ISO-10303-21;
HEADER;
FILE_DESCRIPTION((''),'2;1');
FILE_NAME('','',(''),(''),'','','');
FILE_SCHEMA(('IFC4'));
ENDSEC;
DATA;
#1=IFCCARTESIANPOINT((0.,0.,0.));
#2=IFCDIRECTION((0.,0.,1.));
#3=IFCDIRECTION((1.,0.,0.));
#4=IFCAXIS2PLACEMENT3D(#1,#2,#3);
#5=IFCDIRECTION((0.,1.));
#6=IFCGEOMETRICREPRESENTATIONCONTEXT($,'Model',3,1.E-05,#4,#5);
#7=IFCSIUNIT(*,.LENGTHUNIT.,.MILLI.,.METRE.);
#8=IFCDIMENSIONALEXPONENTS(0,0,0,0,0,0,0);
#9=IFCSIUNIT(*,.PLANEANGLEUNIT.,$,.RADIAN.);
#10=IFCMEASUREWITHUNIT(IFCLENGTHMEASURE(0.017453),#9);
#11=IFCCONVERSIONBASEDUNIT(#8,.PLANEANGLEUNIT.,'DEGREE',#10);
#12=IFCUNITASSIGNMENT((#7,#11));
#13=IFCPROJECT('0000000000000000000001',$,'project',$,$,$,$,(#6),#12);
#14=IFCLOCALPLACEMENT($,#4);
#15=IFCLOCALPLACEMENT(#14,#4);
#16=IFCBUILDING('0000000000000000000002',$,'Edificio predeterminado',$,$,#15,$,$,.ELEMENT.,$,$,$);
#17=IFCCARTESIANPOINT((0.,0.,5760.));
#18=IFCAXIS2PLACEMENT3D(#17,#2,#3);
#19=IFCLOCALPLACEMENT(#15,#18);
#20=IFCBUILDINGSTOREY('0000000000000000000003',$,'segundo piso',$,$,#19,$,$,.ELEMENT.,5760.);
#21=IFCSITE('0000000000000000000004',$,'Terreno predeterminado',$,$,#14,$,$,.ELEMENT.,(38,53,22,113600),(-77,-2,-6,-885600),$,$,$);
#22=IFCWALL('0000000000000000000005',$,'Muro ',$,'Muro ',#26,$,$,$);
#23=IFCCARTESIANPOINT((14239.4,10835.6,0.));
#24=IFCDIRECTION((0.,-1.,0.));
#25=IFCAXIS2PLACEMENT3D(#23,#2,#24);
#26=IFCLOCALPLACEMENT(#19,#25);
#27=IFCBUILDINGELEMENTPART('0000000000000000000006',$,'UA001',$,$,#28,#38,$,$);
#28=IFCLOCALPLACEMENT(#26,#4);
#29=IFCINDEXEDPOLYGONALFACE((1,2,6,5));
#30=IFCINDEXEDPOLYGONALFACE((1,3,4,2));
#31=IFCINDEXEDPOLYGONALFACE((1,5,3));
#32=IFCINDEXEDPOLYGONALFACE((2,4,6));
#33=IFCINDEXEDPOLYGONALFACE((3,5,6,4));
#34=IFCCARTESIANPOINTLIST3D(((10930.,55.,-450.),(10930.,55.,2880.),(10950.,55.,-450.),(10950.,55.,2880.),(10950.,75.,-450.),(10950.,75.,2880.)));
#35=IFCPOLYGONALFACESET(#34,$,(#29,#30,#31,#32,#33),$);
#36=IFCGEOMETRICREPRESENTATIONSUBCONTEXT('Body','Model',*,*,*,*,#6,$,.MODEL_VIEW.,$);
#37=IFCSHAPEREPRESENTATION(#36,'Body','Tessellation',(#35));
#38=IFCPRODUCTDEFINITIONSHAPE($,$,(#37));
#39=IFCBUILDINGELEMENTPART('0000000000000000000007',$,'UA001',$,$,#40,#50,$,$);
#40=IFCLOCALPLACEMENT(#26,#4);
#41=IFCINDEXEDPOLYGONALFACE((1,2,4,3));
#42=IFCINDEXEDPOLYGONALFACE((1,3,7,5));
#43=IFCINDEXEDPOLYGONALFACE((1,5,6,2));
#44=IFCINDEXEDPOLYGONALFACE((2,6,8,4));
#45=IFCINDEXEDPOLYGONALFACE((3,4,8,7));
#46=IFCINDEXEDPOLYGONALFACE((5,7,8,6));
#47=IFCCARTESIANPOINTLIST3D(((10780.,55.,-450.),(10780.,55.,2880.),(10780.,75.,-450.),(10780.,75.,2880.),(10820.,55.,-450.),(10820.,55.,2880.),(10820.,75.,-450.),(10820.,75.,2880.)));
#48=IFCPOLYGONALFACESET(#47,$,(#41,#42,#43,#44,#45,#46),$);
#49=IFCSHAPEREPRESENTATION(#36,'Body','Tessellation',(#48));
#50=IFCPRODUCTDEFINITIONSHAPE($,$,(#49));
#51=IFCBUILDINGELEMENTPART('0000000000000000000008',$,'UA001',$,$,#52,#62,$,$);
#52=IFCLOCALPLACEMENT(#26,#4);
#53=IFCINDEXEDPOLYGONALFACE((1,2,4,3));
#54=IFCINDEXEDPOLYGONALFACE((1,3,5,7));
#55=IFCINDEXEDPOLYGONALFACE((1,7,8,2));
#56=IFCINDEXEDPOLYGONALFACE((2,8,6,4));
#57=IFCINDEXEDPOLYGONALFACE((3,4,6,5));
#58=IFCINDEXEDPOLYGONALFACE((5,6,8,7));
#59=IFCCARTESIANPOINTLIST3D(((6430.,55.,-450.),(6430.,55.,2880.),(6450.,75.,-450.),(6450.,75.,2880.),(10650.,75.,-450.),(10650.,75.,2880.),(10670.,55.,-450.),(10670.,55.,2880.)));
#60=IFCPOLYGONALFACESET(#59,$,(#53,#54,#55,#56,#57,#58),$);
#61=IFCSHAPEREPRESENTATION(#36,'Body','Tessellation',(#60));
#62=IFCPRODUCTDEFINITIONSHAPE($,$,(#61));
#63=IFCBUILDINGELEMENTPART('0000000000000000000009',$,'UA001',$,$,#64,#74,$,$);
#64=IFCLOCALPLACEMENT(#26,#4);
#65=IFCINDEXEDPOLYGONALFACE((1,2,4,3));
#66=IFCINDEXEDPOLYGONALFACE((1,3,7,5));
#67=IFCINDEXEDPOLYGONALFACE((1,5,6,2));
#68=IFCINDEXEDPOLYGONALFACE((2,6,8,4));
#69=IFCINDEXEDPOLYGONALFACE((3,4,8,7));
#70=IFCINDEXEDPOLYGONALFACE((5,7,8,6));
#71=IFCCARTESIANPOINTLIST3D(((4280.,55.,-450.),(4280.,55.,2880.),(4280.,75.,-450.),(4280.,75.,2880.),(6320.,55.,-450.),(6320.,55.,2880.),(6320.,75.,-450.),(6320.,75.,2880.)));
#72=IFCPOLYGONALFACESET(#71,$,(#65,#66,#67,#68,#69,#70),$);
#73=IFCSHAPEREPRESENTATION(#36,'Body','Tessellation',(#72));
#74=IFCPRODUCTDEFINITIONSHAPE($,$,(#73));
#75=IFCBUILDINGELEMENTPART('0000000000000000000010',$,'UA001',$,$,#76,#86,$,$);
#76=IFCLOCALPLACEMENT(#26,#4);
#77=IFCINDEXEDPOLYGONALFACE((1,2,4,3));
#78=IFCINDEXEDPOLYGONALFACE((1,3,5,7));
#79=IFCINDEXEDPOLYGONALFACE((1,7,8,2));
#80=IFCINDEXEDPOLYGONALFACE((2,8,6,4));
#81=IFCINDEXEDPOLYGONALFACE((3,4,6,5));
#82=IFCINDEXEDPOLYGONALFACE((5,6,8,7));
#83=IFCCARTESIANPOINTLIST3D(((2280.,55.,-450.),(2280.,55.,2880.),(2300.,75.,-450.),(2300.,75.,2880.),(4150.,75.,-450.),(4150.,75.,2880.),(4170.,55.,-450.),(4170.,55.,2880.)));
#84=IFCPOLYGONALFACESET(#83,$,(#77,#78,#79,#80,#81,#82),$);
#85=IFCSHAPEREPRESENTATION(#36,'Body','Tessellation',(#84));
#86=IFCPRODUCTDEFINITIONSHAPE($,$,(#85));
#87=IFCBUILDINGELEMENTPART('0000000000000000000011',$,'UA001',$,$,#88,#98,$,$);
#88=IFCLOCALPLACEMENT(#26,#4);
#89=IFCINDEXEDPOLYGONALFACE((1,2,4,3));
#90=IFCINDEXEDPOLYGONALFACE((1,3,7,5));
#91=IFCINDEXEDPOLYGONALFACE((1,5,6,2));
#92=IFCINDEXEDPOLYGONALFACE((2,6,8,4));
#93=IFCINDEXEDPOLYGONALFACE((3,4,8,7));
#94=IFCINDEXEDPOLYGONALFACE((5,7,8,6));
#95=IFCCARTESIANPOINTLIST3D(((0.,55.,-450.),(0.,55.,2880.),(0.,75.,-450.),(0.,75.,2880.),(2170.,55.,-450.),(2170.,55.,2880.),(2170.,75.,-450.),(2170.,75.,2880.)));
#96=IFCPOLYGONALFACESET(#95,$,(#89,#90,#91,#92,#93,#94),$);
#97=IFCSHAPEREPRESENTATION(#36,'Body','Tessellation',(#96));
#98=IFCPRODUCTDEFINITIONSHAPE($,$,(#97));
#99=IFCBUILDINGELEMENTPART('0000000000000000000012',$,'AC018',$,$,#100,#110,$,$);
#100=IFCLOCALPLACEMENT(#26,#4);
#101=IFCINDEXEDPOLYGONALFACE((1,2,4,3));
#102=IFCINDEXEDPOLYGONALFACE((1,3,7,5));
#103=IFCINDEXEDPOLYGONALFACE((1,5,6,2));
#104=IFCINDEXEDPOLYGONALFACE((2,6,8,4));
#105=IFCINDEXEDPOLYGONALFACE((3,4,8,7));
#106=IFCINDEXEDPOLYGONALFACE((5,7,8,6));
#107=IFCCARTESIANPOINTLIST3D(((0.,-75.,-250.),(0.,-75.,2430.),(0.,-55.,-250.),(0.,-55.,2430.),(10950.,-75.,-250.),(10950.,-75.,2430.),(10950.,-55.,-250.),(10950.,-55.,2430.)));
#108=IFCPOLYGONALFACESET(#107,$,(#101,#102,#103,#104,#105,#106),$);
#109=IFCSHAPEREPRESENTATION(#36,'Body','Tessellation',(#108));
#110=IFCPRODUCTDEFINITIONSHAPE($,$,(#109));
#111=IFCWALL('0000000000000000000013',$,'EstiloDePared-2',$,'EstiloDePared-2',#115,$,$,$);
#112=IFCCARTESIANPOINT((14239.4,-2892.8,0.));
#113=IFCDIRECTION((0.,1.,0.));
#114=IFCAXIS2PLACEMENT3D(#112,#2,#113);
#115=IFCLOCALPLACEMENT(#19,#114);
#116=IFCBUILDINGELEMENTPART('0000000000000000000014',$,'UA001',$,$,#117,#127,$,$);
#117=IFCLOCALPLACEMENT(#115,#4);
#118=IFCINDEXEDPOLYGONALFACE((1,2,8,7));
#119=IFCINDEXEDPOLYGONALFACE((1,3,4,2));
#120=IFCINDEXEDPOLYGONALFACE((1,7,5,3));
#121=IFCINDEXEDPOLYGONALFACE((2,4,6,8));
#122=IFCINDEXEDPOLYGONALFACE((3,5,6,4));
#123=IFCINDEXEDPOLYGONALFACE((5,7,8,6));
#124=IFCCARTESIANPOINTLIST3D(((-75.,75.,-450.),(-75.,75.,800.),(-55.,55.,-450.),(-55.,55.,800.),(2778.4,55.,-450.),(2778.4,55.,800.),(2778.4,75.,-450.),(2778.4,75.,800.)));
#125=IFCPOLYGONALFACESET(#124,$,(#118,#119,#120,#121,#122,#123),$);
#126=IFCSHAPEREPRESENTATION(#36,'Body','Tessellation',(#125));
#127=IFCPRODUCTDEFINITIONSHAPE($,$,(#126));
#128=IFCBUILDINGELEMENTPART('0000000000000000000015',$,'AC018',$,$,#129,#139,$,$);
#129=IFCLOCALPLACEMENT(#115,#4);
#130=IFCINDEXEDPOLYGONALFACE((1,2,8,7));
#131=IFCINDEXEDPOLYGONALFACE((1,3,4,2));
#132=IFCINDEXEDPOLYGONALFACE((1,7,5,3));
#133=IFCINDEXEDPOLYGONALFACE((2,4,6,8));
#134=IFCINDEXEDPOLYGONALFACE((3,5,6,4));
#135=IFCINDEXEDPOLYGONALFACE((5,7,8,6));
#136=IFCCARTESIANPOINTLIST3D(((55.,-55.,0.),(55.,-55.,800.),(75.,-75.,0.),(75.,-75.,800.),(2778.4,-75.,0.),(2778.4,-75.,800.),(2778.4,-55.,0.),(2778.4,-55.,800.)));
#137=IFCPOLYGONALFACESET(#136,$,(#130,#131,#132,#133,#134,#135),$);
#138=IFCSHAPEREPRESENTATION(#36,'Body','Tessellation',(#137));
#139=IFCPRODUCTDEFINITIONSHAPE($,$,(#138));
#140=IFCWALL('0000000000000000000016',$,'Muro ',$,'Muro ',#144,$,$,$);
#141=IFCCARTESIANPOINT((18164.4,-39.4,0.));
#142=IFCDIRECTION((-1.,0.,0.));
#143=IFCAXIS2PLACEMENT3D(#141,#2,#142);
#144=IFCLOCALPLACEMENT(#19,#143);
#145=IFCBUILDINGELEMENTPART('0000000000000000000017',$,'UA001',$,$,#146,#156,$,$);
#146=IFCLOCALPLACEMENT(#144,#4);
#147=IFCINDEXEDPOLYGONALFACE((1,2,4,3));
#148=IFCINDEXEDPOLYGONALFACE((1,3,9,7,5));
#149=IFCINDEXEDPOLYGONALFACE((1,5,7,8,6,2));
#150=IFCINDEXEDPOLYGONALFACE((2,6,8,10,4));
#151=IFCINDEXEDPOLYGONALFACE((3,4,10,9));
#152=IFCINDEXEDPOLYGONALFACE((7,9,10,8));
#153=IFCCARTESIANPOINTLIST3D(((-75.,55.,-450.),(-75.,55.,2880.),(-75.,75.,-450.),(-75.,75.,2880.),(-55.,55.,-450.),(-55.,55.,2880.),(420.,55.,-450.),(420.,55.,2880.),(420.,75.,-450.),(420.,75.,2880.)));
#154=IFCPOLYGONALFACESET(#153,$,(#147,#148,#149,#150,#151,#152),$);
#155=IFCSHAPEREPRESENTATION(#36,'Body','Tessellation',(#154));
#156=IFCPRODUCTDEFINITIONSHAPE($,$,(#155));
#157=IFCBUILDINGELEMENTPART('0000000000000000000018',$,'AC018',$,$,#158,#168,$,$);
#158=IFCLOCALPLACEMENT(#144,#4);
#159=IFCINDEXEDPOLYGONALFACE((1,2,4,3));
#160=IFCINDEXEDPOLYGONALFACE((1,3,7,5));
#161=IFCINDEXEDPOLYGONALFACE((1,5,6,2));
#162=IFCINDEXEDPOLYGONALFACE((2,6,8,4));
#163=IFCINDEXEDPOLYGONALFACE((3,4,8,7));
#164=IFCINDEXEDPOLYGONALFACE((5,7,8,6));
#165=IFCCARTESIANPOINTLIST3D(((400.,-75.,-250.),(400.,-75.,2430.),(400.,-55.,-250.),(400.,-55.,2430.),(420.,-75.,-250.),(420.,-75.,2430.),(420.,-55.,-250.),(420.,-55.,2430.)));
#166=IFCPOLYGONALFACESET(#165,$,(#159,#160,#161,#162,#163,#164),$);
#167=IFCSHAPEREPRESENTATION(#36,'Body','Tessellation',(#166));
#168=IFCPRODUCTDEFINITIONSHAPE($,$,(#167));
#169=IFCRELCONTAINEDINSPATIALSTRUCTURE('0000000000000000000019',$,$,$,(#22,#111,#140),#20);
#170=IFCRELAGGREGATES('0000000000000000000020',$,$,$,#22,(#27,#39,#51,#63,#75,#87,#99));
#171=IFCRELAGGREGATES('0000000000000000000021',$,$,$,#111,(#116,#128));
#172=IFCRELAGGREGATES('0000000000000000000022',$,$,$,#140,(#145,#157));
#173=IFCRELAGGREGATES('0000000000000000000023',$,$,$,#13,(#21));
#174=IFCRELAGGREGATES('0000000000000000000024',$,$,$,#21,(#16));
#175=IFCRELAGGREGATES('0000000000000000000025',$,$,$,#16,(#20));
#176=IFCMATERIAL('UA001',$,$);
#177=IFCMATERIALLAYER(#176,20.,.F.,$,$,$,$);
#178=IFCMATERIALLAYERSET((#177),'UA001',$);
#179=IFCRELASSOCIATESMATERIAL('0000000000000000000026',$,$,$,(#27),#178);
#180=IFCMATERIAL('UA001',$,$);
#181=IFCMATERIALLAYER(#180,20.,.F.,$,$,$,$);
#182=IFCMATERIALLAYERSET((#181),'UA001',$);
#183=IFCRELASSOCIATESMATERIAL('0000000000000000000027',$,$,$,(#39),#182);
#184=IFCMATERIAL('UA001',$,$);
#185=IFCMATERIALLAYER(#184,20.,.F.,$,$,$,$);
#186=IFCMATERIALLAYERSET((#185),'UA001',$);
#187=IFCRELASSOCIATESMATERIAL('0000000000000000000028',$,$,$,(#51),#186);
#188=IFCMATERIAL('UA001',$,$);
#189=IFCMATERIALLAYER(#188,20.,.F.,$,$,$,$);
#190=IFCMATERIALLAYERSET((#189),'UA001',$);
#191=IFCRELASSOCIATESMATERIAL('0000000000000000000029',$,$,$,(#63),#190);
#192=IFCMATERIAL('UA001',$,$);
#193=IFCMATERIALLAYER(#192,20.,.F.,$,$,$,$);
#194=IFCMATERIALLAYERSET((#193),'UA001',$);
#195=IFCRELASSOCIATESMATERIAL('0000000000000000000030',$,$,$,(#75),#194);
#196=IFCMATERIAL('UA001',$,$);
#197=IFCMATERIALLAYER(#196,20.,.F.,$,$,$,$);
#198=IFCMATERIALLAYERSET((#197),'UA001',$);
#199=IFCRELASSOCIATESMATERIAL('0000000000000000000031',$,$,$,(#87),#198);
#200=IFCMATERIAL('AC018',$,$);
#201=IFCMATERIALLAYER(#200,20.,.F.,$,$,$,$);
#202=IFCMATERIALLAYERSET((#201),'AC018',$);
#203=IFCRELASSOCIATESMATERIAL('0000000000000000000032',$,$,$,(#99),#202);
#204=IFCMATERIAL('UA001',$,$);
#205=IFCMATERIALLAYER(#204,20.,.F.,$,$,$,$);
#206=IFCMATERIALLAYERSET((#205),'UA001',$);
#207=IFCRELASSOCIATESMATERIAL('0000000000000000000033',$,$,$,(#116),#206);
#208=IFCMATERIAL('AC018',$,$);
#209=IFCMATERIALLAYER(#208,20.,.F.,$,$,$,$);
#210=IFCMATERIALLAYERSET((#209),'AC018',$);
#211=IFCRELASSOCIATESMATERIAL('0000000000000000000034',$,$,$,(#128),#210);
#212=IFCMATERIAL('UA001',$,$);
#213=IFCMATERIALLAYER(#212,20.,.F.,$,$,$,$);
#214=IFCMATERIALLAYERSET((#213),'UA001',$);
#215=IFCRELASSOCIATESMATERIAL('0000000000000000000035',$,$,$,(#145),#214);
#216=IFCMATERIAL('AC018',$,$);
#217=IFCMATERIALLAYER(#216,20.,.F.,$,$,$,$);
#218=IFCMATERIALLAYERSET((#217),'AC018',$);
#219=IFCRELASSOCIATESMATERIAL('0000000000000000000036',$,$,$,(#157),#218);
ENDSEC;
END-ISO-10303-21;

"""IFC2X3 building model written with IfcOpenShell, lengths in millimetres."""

from ifc_helpers import new_model, entity, si_unit, converted_unit, direction, frame, origin_with_axes, place, context, subcontext, project, spatial, polyline, outline, extrude, material, layer, layer_set, layer_usage, element, aggregate, save


model = new_model("IFC2X3")

# Units and contexts
model_context = context("Model", 3, precision=1e-05, world=origin_with_axes(), true_north=direction((0.0, 1.0)))
body_context = subcontext(model_context, "Body", "Model", "MODEL_VIEW")
ifc_project = project(units=[si_unit("LENGTHUNIT", "METRE", prefix="MILLI"), converted_unit("PLANEANGLEUNIT", "DEGREE", entity("IfcLengthMeasure", 0.017453), si_unit("PLANEANGLEUNIT", "RADIAN"), dimensions=[0, 0, 0, 0, 0, 0, 0])], contexts=[model_context])

# Site, building, storey
site_placement = place(None, origin_with_axes())
site = spatial("IfcSite", under=ifc_project, at=site_placement, Name="Terreno predeterminado", CompositionType="ELEMENT", RefLatitude=(38, 53, 22, 113600), RefLongitude=(-77, -2, -6, -885600))
building_placement = place(site_placement, origin_with_axes())
building = spatial("IfcBuilding", under=site, at=building_placement, Name="Edificio predeterminado", CompositionType="ELEMENT")
storey_placement = place(building_placement, frame((0.0, 0.0, 5760.0), z_axis=(0.0, 0.0, 1.0), x_axis=(1.0, 0.0, 0.0)))
storey = spatial("IfcBuildingStorey", under=building, at=storey_placement, Name="segundo piso", CompositionType="ELEMENT", Elevation=5760.0)

# Walls, building element parts
wall_1_placement = place(storey_placement, frame((14239.4, 10835.6, 0.0), z_axis=(0.0, 0.0, 1.0), x_axis=(0.0, -1.0, 0.0)))
wall_1 = element("IfcWall", 1, at=wall_1_placement, inside=storey, Name="Muro ", ObjectType="Muro ")
ifc_material_1 = material(Name="UA001")
ifc_layer_1 = layer(ifc_material_1, 20.0, ventilated=False)
ifc_layer_set_1 = layer_set([ifc_layer_1], Name="UA001")
ifc_layer_usage_1 = layer_usage(ifc_layer_set_1, "AXIS2", "NEGATIVE", -75.0)
building_element_part_1_placement = place(wall_1_placement, origin_with_axes())
building_element_part_1 = element("IfcBuildingElementPart", 2, at=building_element_part_1_placement, material=ifc_layer_usage_1, Name="UA001", context=body_context, shape_type="SweptSolid", body=[
    extrude(outline(polyline([(10950.0, 75.0), (10950.0, 55.0), (10930.0, 55.0), (10950.0, 75.0)])), frame((0.0, 0.0, -450.0), z_axis=(0.0, 0.0, 1.0), x_axis=(1.0, 0.0, 0.0)), (0.0, 0.0, 1.0), 3330.0),
])
ifc_material_2 = material(Name="UA001")
ifc_layer_2 = layer(ifc_material_2, 20.0, ventilated=False)
ifc_layer_set_2 = layer_set([ifc_layer_2], Name="UA001")
ifc_layer_usage_2 = layer_usage(ifc_layer_set_2, "AXIS2", "NEGATIVE", -75.0)
building_element_part_2_placement = place(wall_1_placement, origin_with_axes())
building_element_part_2 = element("IfcBuildingElementPart", 3, at=building_element_part_2_placement, material=ifc_layer_usage_2, Name="UA001", context=body_context, shape_type="SweptSolid", body=[
    extrude(outline(polyline([(10820.0, 75.0), (10820.0, 55.0), (10780.0, 55.0), (10780.0, 75.0), (10820.0, 75.0)])), frame((0.0, 0.0, -450.0), z_axis=(0.0, 0.0, 1.0), x_axis=(1.0, 0.0, 0.0)), (0.0, 0.0, 1.0), 3330.0),
])
ifc_material_3 = material(Name="UA001")
ifc_layer_3 = layer(ifc_material_3, 20.0, ventilated=False)
ifc_layer_set_3 = layer_set([ifc_layer_3], Name="UA001")
ifc_layer_usage_3 = layer_usage(ifc_layer_set_3, "AXIS2", "NEGATIVE", -75.0)
building_element_part_3_placement = place(wall_1_placement, origin_with_axes())
building_element_part_3 = element("IfcBuildingElementPart", 4, at=building_element_part_3_placement, material=ifc_layer_usage_3, Name="UA001", context=body_context, shape_type="SweptSolid", body=[
    extrude(outline(polyline([(10650.0, 75.0), (10670.0, 55.0), (6430.0, 55.0), (6450.0, 75.0), (10650.0, 75.0)])), frame((0.0, 0.0, -450.0), z_axis=(0.0, 0.0, 1.0), x_axis=(1.0, 0.0, 0.0)), (0.0, 0.0, 1.0), 3330.0),
])
ifc_material_4 = material(Name="UA001")
ifc_layer_4 = layer(ifc_material_4, 20.0, ventilated=False)
ifc_layer_set_4 = layer_set([ifc_layer_4], Name="UA001")
ifc_layer_usage_4 = layer_usage(ifc_layer_set_4, "AXIS2", "NEGATIVE", -75.0)
building_element_part_4_placement = place(wall_1_placement, origin_with_axes())
building_element_part_4 = element("IfcBuildingElementPart", 5, at=building_element_part_4_placement, material=ifc_layer_usage_4, Name="UA001", context=body_context, shape_type="SweptSolid", body=[
    extrude(outline(polyline([(4280.0, 75.0), (6320.0, 75.0), (6320.0, 55.0), (4280.0, 55.0), (4280.0, 75.0)])), frame((0.0, 0.0, -450.0), z_axis=(0.0, 0.0, 1.0), x_axis=(1.0, 0.0, 0.0)), (0.0, 0.0, 1.0), 3330.0),
])
ifc_material_5 = material(Name="UA001")
ifc_layer_5 = layer(ifc_material_5, 20.0, ventilated=False)
ifc_layer_set_5 = layer_set([ifc_layer_5], Name="UA001")
ifc_layer_usage_5 = layer_usage(ifc_layer_set_5, "AXIS2", "NEGATIVE", -75.0)
building_element_part_5_placement = place(wall_1_placement, origin_with_axes())
building_element_part_5 = element("IfcBuildingElementPart", 6, at=building_element_part_5_placement, material=ifc_layer_usage_5, Name="UA001", context=body_context, shape_type="SweptSolid", body=[
    extrude(outline(polyline([(4150.0, 75.0), (4170.0, 55.0), (2280.0, 55.0), (2300.0, 75.0), (4150.0, 75.0)])), frame((0.0, 0.0, -450.0), z_axis=(0.0, 0.0, 1.0), x_axis=(1.0, 0.0, 0.0)), (0.0, 0.0, 1.0), 3330.0),
])
ifc_material_6 = material(Name="UA001")
ifc_layer_6 = layer(ifc_material_6, 20.0, ventilated=False)
ifc_layer_set_6 = layer_set([ifc_layer_6], Name="UA001")
ifc_layer_usage_6 = layer_usage(ifc_layer_set_6, "AXIS2", "NEGATIVE", -75.0)
building_element_part_6_placement = place(wall_1_placement, origin_with_axes())
building_element_part_6 = element("IfcBuildingElementPart", 7, at=building_element_part_6_placement, material=ifc_layer_usage_6, Name="UA001", context=body_context, shape_type="SweptSolid", body=[
    extrude(outline(polyline([(2170.0, 75.0), (2170.0, 55.0), (0.0, 55.0), (0.0, 75.0), (2170.0, 75.0)])), frame((0.0, 0.0, -450.0), z_axis=(0.0, 0.0, 1.0), x_axis=(1.0, 0.0, 0.0)), (0.0, 0.0, 1.0), 3330.0),
])
ifc_material_7 = material(Name="AC018")
ifc_layer_7 = layer(ifc_material_7, 20.0, ventilated=False)
ifc_layer_set_7 = layer_set([ifc_layer_7], Name="AC018")
ifc_layer_usage_7 = layer_usage(ifc_layer_set_7, "AXIS2", "NEGATIVE", 55.0)
building_element_part_7_placement = place(wall_1_placement, origin_with_axes())
building_element_part_7 = element("IfcBuildingElementPart", 8, at=building_element_part_7_placement, material=ifc_layer_usage_7, Name="AC018", context=body_context, shape_type="SweptSolid", body=[
    extrude(outline(polyline([(10950.0, -55.0), (10950.0, -75.0), (0.0, -75.0), (0.0, -55.0), (10950.0, -55.0)])), frame((0.0, 0.0, -250.0), z_axis=(0.0, 0.0, 1.0), x_axis=(1.0, 0.0, 0.0)), (0.0, 0.0, 1.0), 2680.0),
])
aggregate(wall_1, [building_element_part_1, building_element_part_2, building_element_part_3, building_element_part_4, building_element_part_5, building_element_part_6, building_element_part_7])
wall_2_placement = place(storey_placement, frame((14239.4, -2892.8, 0.0), z_axis=(0.0, 0.0, 1.0), x_axis=(0.0, 1.0, 0.0)))
wall_2 = element("IfcWall", 9, at=wall_2_placement, inside=storey, Name="EstiloDePared-2", ObjectType="EstiloDePared-2")
ifc_material_8 = material(Name="UA001")
ifc_layer_8 = layer(ifc_material_8, 20.0, ventilated=False)
ifc_layer_set_8 = layer_set([ifc_layer_8], Name="UA001")
ifc_layer_usage_8 = layer_usage(ifc_layer_set_8, "AXIS2", "NEGATIVE", -75.0)
building_element_part_8_placement = place(wall_2_placement, origin_with_axes())
building_element_part_8 = element("IfcBuildingElementPart", 10, at=building_element_part_8_placement, material=ifc_layer_usage_8, Name="UA001", context=body_context, shape_type="SweptSolid", body=[
    extrude(outline(polyline([(2778.4, 75.0), (2778.4, 55.0), (-55.0, 55.0), (-75.0, 75.0), (2778.4, 75.0)])), frame((0.0, 0.0, -450.0), z_axis=(0.0, 0.0, 1.0), x_axis=(1.0, 0.0, 0.0)), (0.0, 0.0, 1.0), 1250.0),
])
ifc_material_9 = material(Name="AC018")
ifc_layer_9 = layer(ifc_material_9, 20.0, ventilated=False)
ifc_layer_set_9 = layer_set([ifc_layer_9], Name="AC018")
ifc_layer_usage_9 = layer_usage(ifc_layer_set_9, "AXIS2", "NEGATIVE", 55.0)
building_element_part_9_placement = place(wall_2_placement, origin_with_axes())
building_element_part_9 = element("IfcBuildingElementPart", 11, at=building_element_part_9_placement, material=ifc_layer_usage_9, Name="AC018", context=body_context, shape_type="SweptSolid", body=[
    extrude(outline(polyline([(2778.4, -55.0), (2778.4, -75.0), (75.0, -75.0), (55.0, -55.0), (2778.4, -55.0)])), origin_with_axes(), (0.0, 0.0, 1.0), 800.0),
])
aggregate(wall_2, [building_element_part_8, building_element_part_9])
wall_3_placement = place(storey_placement, frame((18164.4, -39.4, 0.0), z_axis=(0.0, 0.0, 1.0), x_axis=(-1.0, 0.0, 0.0)))
wall_3 = element("IfcWall", 12, at=wall_3_placement, inside=storey, Name="Muro ", ObjectType="Muro ")
ifc_material_10 = material(Name="UA001")
ifc_layer_10 = layer(ifc_material_10, 20.0, ventilated=False)
ifc_layer_set_10 = layer_set([ifc_layer_10], Name="UA001")
ifc_layer_usage_10 = layer_usage(ifc_layer_set_10, "AXIS2", "NEGATIVE", -75.0)
building_element_part_10_placement = place(wall_3_placement, origin_with_axes())
building_element_part_10 = element("IfcBuildingElementPart", 13, at=building_element_part_10_placement, material=ifc_layer_usage_10, Name="UA001", context=body_context, shape_type="SweptSolid", body=[
    extrude(outline(polyline([(420.0, 75.0), (420.0, 55.0), (-55.0, 55.0), (-75.0, 55.0), (-75.0, 75.0), (420.0, 75.0)])), frame((0.0, 0.0, -450.0), z_axis=(0.0, 0.0, 1.0), x_axis=(1.0, 0.0, 0.0)), (0.0, 0.0, 1.0), 3330.0),
])
ifc_material_11 = material(Name="AC018")
ifc_layer_11 = layer(ifc_material_11, 20.0, ventilated=False)
ifc_layer_set_11 = layer_set([ifc_layer_11], Name="AC018")
ifc_layer_usage_11 = layer_usage(ifc_layer_set_11, "AXIS2", "NEGATIVE", 55.0)
building_element_part_11_placement = place(wall_3_placement, origin_with_axes())
building_element_part_11 = element("IfcBuildingElementPart", 14, at=building_element_part_11_placement, material=ifc_layer_usage_11, Name="AC018", context=body_context, shape_type="SweptSolid", body=[
    extrude(outline(polyline([(420.0, -55.0), (420.0, -75.0), (400.0, -75.0), (400.0, -55.0), (420.0, -55.0)])), frame((0.0, 0.0, -250.0), z_axis=(0.0, 0.0, 1.0), x_axis=(1.0, 0.0, 0.0)), (0.0, 0.0, 1.0), 2680.0),
])
aggregate(wall_3, [building_element_part_10, building_element_part_11])

save(model, "model.ifc")
